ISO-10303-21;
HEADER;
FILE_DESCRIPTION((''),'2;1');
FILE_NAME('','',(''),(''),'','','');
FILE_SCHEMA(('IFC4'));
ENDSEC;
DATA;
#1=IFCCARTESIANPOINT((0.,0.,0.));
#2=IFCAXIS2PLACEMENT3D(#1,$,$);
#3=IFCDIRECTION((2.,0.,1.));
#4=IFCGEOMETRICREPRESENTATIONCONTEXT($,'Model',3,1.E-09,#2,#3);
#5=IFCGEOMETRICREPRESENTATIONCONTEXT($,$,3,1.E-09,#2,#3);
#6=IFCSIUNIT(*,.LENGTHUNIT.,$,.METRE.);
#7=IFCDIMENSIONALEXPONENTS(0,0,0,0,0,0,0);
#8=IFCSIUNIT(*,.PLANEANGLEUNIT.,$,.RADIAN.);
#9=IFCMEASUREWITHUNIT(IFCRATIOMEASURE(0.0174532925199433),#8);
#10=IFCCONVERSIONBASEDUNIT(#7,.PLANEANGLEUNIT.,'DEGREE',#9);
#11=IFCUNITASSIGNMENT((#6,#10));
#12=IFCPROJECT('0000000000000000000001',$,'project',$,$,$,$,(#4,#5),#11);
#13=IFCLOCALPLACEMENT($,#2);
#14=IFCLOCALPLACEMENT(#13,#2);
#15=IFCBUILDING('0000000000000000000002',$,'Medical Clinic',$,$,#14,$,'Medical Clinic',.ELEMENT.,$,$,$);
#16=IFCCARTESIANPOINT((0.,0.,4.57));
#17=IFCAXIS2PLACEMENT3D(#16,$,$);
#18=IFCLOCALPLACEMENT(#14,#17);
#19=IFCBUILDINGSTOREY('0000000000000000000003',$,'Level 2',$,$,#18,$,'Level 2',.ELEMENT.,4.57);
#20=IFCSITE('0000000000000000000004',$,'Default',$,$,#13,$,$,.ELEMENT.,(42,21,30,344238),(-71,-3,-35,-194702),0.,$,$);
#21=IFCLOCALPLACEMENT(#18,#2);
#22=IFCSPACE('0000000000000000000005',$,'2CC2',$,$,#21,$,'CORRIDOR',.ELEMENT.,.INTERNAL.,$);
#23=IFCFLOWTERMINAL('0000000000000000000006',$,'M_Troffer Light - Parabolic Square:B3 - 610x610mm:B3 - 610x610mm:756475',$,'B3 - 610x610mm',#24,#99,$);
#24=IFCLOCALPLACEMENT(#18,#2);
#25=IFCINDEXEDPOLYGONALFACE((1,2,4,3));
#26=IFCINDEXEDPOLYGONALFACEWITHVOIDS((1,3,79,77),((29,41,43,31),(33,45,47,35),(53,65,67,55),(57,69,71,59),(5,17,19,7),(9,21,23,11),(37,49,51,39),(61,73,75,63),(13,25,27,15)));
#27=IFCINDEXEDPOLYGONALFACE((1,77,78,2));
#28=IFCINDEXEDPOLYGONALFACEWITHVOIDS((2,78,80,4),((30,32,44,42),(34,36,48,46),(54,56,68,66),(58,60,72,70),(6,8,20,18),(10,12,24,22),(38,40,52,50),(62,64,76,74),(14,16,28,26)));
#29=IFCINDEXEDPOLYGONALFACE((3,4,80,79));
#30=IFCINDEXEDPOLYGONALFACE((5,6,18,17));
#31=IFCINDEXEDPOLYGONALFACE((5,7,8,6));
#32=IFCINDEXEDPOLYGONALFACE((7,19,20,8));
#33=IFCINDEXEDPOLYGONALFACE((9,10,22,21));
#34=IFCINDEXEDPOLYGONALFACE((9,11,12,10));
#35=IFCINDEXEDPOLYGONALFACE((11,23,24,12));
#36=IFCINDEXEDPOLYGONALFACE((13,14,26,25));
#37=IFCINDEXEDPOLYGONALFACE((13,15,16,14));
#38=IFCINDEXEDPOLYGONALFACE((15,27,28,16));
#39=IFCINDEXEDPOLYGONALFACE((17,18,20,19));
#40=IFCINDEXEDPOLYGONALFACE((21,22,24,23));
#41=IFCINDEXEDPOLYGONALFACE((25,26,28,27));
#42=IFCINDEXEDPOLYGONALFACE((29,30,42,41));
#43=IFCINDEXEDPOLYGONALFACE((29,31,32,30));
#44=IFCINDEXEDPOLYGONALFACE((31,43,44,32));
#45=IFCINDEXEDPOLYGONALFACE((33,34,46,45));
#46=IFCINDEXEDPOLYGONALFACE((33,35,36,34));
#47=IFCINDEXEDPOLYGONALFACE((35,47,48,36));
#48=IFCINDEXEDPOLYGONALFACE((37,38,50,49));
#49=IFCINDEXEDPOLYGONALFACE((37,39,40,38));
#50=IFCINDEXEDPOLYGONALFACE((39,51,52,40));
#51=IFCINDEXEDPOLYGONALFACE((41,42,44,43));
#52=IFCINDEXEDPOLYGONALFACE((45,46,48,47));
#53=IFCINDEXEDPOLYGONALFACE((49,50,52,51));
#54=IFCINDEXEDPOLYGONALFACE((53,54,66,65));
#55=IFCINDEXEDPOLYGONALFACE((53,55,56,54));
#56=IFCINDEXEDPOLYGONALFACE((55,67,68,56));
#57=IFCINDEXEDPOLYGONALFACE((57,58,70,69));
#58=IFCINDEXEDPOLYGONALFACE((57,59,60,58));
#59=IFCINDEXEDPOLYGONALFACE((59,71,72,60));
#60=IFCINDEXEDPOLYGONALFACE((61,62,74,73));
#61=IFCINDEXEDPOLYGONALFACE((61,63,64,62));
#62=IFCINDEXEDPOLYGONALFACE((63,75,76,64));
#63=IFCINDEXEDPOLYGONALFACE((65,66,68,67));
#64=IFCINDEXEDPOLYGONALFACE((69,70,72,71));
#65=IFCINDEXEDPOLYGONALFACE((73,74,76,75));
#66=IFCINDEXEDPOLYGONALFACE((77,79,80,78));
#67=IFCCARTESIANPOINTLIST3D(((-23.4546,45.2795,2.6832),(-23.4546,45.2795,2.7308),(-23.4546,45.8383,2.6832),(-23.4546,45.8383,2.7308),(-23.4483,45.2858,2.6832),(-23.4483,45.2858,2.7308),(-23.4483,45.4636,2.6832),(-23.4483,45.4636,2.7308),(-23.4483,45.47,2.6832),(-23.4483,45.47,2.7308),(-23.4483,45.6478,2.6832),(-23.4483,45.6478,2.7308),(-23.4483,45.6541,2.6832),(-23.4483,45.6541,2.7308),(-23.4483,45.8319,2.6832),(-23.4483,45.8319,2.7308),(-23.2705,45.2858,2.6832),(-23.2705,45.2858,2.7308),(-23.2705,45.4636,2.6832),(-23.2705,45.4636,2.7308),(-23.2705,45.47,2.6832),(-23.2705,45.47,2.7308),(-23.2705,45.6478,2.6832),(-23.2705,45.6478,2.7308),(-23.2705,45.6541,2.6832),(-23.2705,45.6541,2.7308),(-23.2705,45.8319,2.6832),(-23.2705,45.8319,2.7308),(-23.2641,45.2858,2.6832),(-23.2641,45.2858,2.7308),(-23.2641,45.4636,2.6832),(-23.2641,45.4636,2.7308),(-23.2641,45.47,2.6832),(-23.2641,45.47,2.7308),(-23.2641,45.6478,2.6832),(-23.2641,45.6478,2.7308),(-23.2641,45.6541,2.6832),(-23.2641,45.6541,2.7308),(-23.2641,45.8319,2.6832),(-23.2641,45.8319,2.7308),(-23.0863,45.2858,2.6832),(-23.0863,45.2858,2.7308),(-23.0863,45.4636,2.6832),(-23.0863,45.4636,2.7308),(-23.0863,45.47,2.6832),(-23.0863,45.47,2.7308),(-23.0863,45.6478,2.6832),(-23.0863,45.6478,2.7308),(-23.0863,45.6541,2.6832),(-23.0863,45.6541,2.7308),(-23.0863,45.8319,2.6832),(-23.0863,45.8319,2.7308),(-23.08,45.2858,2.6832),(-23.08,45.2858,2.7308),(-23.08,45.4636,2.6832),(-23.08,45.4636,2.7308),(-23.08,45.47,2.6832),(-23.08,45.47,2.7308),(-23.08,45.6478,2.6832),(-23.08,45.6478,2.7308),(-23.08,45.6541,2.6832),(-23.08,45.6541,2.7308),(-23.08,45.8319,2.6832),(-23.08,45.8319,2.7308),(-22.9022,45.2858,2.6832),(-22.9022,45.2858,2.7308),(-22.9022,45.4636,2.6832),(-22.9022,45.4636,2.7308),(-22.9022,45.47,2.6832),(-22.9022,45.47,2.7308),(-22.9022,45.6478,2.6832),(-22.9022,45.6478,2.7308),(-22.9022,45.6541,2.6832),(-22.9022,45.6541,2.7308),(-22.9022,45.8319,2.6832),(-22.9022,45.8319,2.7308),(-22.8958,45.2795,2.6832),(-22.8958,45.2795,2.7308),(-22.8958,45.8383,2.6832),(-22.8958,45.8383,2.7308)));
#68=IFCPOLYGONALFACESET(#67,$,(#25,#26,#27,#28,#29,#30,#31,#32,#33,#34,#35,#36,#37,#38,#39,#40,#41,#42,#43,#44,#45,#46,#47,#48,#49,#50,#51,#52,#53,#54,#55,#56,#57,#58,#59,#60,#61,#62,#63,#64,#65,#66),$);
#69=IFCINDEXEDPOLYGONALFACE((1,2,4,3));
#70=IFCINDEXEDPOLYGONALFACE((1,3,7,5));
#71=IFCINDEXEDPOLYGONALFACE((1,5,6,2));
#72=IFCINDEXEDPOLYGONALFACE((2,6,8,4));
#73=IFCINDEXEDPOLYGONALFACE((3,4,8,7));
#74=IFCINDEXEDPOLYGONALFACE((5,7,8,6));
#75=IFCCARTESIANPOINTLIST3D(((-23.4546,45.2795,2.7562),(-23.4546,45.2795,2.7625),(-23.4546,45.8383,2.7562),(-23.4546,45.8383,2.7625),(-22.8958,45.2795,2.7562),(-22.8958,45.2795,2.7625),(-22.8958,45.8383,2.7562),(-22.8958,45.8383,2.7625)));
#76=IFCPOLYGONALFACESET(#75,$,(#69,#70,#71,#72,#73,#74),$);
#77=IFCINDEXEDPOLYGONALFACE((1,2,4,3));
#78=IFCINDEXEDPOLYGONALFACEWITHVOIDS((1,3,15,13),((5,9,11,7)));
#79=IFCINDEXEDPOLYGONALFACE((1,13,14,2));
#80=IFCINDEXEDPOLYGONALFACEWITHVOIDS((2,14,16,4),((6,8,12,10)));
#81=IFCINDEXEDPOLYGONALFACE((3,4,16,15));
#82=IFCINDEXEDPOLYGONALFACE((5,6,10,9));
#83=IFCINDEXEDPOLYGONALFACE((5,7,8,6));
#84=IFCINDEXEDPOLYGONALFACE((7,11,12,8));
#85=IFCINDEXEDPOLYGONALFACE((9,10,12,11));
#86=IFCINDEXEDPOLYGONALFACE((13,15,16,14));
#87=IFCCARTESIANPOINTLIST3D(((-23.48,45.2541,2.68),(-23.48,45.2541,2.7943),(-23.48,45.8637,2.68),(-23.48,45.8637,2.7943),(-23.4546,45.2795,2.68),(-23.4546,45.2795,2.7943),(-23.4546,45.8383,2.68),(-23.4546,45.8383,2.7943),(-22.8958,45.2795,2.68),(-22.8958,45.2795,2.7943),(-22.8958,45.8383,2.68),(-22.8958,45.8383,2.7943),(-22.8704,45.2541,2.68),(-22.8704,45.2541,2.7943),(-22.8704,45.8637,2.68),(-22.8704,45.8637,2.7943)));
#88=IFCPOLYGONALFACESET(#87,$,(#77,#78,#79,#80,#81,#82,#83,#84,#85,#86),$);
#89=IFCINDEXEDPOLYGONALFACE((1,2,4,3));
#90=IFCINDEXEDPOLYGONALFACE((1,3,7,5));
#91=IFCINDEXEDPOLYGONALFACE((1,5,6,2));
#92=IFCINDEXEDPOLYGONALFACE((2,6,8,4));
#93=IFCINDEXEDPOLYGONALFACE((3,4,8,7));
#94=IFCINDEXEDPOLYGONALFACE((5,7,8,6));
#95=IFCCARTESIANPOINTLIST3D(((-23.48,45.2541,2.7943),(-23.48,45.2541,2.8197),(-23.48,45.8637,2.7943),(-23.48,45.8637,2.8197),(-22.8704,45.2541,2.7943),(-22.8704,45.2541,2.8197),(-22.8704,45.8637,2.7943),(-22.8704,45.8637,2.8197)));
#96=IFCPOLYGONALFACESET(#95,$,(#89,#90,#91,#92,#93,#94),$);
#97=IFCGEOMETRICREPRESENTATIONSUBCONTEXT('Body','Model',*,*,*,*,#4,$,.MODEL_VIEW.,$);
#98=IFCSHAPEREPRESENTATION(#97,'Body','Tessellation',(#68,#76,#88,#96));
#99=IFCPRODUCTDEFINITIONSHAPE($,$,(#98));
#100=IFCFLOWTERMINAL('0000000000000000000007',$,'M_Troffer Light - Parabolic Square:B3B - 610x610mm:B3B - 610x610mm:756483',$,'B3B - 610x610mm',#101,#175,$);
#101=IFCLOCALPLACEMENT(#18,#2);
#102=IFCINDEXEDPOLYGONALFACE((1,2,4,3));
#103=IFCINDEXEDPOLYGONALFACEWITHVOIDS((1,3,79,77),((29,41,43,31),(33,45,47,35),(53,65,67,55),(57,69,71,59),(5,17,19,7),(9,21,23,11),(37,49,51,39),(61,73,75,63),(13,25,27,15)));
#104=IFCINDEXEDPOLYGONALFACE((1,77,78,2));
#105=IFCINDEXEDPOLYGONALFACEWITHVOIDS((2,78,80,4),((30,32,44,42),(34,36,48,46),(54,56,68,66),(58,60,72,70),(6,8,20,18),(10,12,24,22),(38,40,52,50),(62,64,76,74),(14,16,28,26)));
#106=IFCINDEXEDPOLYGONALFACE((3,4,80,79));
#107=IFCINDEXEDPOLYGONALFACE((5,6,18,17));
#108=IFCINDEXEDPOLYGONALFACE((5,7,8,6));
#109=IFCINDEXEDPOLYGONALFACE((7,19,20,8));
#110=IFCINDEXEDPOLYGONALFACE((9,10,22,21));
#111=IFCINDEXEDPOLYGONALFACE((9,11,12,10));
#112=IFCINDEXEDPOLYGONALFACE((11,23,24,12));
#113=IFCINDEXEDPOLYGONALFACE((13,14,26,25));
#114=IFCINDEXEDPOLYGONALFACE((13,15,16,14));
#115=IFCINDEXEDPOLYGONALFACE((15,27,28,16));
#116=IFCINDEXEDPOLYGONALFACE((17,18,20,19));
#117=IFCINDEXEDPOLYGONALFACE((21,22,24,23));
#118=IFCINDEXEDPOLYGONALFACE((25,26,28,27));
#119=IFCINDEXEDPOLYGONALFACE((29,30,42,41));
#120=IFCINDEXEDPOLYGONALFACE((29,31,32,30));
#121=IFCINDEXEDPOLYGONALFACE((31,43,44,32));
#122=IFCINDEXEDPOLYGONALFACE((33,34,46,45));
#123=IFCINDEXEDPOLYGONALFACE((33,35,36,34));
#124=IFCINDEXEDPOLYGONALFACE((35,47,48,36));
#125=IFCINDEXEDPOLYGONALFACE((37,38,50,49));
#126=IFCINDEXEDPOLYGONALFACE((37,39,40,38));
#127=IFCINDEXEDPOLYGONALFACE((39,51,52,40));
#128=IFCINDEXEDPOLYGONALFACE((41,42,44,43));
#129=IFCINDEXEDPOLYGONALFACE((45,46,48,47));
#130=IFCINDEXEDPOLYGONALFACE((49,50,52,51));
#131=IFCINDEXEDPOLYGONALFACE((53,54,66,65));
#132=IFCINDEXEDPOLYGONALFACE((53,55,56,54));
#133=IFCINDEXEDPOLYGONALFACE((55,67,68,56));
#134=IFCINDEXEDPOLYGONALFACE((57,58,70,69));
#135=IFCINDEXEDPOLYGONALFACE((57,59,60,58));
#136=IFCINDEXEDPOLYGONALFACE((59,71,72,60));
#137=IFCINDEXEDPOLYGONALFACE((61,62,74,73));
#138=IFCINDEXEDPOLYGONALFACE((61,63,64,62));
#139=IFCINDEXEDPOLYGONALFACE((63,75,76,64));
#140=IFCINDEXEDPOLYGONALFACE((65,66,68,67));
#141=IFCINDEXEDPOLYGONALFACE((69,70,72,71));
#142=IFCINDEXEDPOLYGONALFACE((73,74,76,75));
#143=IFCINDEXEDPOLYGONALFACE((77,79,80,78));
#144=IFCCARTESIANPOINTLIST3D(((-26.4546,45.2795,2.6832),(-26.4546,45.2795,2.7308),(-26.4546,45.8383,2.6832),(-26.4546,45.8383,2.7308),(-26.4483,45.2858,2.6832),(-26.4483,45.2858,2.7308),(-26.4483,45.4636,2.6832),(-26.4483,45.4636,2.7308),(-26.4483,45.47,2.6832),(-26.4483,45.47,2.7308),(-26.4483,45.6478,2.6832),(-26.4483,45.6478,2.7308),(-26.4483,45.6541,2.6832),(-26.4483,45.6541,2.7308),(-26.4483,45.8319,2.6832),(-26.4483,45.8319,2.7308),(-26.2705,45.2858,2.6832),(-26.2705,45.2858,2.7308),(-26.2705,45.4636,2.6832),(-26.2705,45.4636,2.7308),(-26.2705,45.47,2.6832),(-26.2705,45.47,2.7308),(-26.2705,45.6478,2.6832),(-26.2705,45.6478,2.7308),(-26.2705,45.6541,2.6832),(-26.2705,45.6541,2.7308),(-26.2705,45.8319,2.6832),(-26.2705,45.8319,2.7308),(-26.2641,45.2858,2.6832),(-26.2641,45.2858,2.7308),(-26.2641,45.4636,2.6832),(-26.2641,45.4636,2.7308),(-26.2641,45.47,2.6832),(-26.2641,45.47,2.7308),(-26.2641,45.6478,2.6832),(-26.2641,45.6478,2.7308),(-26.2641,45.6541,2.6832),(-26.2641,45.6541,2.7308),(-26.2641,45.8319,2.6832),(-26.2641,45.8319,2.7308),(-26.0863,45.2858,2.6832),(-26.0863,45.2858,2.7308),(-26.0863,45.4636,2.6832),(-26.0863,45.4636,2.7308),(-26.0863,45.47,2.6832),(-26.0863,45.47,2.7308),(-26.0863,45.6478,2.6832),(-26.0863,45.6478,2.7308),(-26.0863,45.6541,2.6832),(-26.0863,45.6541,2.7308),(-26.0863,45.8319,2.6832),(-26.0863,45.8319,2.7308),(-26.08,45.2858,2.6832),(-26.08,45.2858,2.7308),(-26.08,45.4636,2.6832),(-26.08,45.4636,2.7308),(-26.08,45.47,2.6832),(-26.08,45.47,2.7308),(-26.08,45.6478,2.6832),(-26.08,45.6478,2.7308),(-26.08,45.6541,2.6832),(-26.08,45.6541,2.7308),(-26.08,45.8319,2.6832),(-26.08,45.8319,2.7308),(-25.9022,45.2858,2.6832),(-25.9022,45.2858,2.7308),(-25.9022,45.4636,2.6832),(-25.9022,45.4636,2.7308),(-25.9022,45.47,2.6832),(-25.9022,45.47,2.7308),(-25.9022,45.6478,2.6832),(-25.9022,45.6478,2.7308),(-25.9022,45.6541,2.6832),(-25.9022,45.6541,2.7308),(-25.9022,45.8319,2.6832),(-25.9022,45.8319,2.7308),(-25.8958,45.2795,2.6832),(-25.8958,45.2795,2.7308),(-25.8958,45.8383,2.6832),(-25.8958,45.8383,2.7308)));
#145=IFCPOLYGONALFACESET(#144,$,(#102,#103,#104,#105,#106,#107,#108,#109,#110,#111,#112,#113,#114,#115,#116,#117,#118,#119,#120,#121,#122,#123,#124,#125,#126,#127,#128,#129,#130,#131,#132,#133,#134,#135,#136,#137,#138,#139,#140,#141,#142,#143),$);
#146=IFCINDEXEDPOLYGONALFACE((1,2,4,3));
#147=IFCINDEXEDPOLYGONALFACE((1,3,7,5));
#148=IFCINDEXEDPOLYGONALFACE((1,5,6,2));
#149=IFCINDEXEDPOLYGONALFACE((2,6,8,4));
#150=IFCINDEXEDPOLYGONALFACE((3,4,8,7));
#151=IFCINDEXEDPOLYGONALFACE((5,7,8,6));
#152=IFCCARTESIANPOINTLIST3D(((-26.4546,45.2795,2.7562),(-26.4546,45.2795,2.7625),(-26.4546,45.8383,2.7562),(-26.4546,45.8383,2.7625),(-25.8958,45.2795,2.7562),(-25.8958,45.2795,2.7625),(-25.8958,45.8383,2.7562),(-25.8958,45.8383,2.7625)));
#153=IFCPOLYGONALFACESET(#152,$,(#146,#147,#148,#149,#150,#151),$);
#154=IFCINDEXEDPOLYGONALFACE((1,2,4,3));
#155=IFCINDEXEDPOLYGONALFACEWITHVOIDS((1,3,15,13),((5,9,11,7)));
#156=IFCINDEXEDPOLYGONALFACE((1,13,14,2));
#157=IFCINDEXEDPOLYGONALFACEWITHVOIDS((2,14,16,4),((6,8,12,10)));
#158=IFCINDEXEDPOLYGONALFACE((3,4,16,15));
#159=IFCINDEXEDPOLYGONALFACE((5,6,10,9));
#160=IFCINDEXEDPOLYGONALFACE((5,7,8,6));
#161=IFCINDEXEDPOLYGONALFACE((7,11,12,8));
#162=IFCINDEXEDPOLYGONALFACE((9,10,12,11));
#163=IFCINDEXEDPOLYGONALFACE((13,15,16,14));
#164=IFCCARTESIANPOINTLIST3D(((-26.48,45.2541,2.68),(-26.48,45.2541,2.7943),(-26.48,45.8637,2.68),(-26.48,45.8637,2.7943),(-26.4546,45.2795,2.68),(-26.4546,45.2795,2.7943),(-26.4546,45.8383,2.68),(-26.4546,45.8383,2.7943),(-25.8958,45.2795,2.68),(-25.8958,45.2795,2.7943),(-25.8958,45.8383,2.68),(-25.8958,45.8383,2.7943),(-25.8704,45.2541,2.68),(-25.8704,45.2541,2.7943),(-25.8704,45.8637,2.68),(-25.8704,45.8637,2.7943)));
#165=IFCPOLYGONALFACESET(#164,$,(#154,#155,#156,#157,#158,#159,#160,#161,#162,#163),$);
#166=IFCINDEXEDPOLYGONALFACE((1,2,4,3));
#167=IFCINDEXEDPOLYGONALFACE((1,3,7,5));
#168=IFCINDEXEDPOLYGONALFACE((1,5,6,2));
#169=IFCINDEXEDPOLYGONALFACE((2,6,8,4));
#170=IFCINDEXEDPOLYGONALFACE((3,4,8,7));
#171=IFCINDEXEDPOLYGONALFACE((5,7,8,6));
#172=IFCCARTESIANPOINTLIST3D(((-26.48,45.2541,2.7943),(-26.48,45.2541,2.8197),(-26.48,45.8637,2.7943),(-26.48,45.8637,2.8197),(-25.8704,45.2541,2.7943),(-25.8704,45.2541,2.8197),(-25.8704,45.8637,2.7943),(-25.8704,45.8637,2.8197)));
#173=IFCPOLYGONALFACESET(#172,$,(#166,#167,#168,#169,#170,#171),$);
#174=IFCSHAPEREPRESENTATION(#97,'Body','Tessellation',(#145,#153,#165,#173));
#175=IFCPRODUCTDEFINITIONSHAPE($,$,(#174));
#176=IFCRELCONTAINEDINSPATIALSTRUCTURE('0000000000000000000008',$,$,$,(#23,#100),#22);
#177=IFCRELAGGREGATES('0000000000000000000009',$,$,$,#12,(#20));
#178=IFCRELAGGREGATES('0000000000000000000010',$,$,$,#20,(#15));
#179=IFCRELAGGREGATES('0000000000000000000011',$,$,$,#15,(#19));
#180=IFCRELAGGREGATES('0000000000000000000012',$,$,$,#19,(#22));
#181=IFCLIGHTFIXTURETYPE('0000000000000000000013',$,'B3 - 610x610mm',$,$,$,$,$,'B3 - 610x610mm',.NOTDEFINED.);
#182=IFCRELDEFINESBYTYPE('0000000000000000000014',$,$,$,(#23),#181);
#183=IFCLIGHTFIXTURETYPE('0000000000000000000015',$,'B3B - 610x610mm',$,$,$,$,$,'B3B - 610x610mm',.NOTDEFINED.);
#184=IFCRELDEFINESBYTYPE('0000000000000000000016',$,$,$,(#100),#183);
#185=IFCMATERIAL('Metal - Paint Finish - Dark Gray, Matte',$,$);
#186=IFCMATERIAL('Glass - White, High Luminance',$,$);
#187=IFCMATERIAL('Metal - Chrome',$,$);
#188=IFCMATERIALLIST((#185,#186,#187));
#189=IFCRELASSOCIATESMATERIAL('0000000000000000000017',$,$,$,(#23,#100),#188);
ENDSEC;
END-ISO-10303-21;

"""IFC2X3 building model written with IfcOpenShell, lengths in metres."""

from ifc_helpers import new_model, entity, si_unit, converted_unit, direction, frame, origin, origin_2d_with_axis, place, context, subcontext, project, spatial, polyline, rectangle, outline, extrude, source, transform, mapped, material, material_list, type_object, type_shapes, element, save


model = new_model("IFC2X3")

# Units and contexts
model_context = context("Model", 3, precision=1e-09, world=origin(), true_north=direction((2.0, 0.0, 1.0)))
context_of_model = context(None, 3, precision=1e-09, world=origin(), true_north=direction((2.0, 0.0, 1.0)))
body_context = subcontext(model_context, "Body", "Model", "MODEL_VIEW")
ifc_project = project(units=[si_unit("LENGTHUNIT", "METRE"), converted_unit("PLANEANGLEUNIT", "DEGREE", entity("IfcRatioMeasure", 0.0174532925199433), si_unit("PLANEANGLEUNIT", "RADIAN"), dimensions=[0, 0, 0, 0, 0, 0, 0])], contexts=[model_context, context_of_model])

# Site, building, storey
site_placement = place(None, origin())
site = spatial("IfcSite", under=ifc_project, at=site_placement, Name="Default", CompositionType="ELEMENT", RefLatitude=(42, 21, 30, 344238), RefLongitude=(-71, -3, -35, -194702), RefElevation=0.0)
building_placement = place(site_placement, origin())
building = spatial("IfcBuilding", under=site, at=building_placement, Name="Medical Clinic", LongName="Medical Clinic", CompositionType="ELEMENT")
storey_placement = place(building_placement, frame((0.0, 0.0, 4.57)))
storey = spatial("IfcBuildingStorey", under=building, at=storey_placement, Name="Level 2", LongName="Level 2", CompositionType="ELEMENT", Elevation=4.57)

# Shared definitions
space_1_placement = place(storey_placement, origin())
space_1 = spatial("IfcSpace", under=storey, at=space_1_placement, Name="2CC2", LongName="CORRIDOR", CompositionType="ELEMENT", InteriorOrExteriorSpace="INTERNAL")

# Flow terminals
ifc_material_1 = material(Name="Metal - Paint Finish - Dark Gray, Matte")
ifc_material_2 = material(Name="Glass - White, High Luminance")
ifc_material_3 = material(Name="Metal - Chrome")
ifc_material_list_1 = material_list([ifc_material_1, ifc_material_2, ifc_material_3])
light_fixture_type_1 = type_object("IfcLightFixtureType", Name="B3 - 610x610mm", ElementType="B3 - 610x610mm", PredefinedType="NOTDEFINED")
shared_shape_1 = source(origin(), body_context, "Body", "SweptSolid", [
    extrude(outline(polyline([(-0.2794, -0.2794), (0.2794, -0.2794), (0.2794, 0.2794), (-0.2794, 0.2794), (-0.2794, -0.2794)]), holes=[polyline([(-0.0952, 0.0953), (-0.273, 0.0953), (-0.273, 0.2731), (-0.0952, 0.2731), (-0.0952, 0.0953)]), polyline([(0.2731, 0.0953), (0.0953, 0.0953), (0.0953, 0.2731), (0.2731, 0.2731), (0.2731, 0.0953)]), polyline([(-0.0889, 0.2731), (0.0889, 0.2731), (0.0889, 0.0953), (-0.0889, 0.0953), (-0.0889, 0.2731)]), polyline([(0.2731, -0.273), (0.0953, -0.273), (0.0953, -0.0952), (0.2731, -0.0952), (0.2731, -0.273)]), polyline([(0.0889, -0.273), (-0.0889, -0.273), (-0.0889, -0.0952), (0.0889, -0.0952), (0.0889, -0.273)]), polyline([(-0.0952, -0.273), (-0.273, -0.273), (-0.273, -0.0952), (-0.0952, -0.0952), (-0.0952, -0.273)]), polyline([(-0.0952, -0.0889), (-0.273, -0.0889), (-0.273, 0.0889), (-0.0952, 0.0889), (-0.0952, -0.0889)]), polyline([(0.0889, -0.0889), (-0.0889, -0.0889), (-0.0889, 0.0889), (0.0889, 0.0889), (0.0889, -0.0889)]), polyline([(0.2731, -0.0889), (0.0953, -0.0889), (0.0953, 0.0889), (0.2731, 0.0889), (0.2731, -0.0889)])]), frame((0.0, -0.3048, -0.0508), z_axis=(0.0, 0.0, 1.0), x_axis=(-1.0, 0.0, 0.0)), (0.0, 0.0, 1.0), 0.0476),
    extrude(rectangle(XDim=0.5588, YDim=0.5588, at=origin_2d_with_axis()), frame((0.0, -0.3048, -0.0825), z_axis=(0.0, 0.0, 1.0), x_axis=(-1.0, 0.0, 0.0)), (0.0, 0.0, 1.0), 0.0064),
    extrude(outline(polyline([(-0.3048, -0.3048), (0.3048, -0.3048), (0.3048, 0.3048), (-0.3048, 0.3048), (-0.3048, -0.3048)]), holes=[polyline([(0.2794, 0.2794), (0.2794, -0.2794), (-0.2794, -0.2794), (-0.2794, 0.2794), (0.2794, 0.2794)])]), frame((0.0, -0.3048, -0.1143)), (0.0, 0.0, 1.0), 0.1143),
    extrude(rectangle(XDim=0.6096, YDim=0.6096, at=origin_2d_with_axis()), frame((0.0, -0.3048, -0.1397), z_axis=(0.0, 0.0, 1.0), x_axis=(-1.0, 0.0, 0.0)), (0.0, 0.0, 1.0), 0.0254),
])
type_shapes(light_fixture_type_1, [shared_shape_1])
flow_terminal_1_placement = place(space_1_placement, frame((-23.1752, 45.2541, 2.68), z_axis=(0.0, 0.0, -1.0), x_axis=(1.0, 0.0, 0.0)))
element("IfcFlowTerminal", 1, at=flow_terminal_1_placement, inside=space_1, type_object=light_fixture_type_1, material=ifc_material_list_1, Name="M_Troffer Light - Parabolic Square:B3 - 610x610mm:B3 - 610x610mm:756475", ObjectType="B3 - 610x610mm", context=body_context, shape_type="MappedRepresentation", body=[
    mapped(shared_shape_1, transform((0.0, 0.0, 0.0), scale=1.0)),
])
light_fixture_type_2 = type_object("IfcLightFixtureType", Name="B3B - 610x610mm", ElementType="B3B - 610x610mm", PredefinedType="NOTDEFINED")
shared_shape_2 = source(origin(), body_context, "Body", "SweptSolid", [
    extrude(outline(polyline([(-0.2794, -0.2794), (0.2794, -0.2794), (0.2794, 0.2794), (-0.2794, 0.2794), (-0.2794, -0.2794)]), holes=[polyline([(-0.0952, 0.0953), (-0.273, 0.0953), (-0.273, 0.2731), (-0.0952, 0.2731), (-0.0952, 0.0953)]), polyline([(0.2731, 0.0953), (0.0953, 0.0953), (0.0953, 0.2731), (0.2731, 0.2731), (0.2731, 0.0953)]), polyline([(-0.0889, 0.2731), (0.0889, 0.2731), (0.0889, 0.0953), (-0.0889, 0.0953), (-0.0889, 0.2731)]), polyline([(0.2731, -0.273), (0.0953, -0.273), (0.0953, -0.0952), (0.2731, -0.0952), (0.2731, -0.273)]), polyline([(0.0889, -0.273), (-0.0889, -0.273), (-0.0889, -0.0952), (0.0889, -0.0952), (0.0889, -0.273)]), polyline([(-0.0952, -0.273), (-0.273, -0.273), (-0.273, -0.0952), (-0.0952, -0.0952), (-0.0952, -0.273)]), polyline([(-0.0952, -0.0889), (-0.273, -0.0889), (-0.273, 0.0889), (-0.0952, 0.0889), (-0.0952, -0.0889)]), polyline([(0.0889, -0.0889), (-0.0889, -0.0889), (-0.0889, 0.0889), (0.0889, 0.0889), (0.0889, -0.0889)]), polyline([(0.2731, -0.0889), (0.0953, -0.0889), (0.0953, 0.0889), (0.2731, 0.0889), (0.2731, -0.0889)])]), frame((0.0, -0.3048, -0.0508), z_axis=(0.0, 0.0, 1.0), x_axis=(-1.0, 0.0, 0.0)), (0.0, 0.0, 1.0), 0.0476),
    extrude(rectangle(XDim=0.5588, YDim=0.5588, at=origin_2d_with_axis()), frame((0.0, -0.3048, -0.0825), z_axis=(0.0, 0.0, 1.0), x_axis=(-1.0, 0.0, 0.0)), (0.0, 0.0, 1.0), 0.0064),
    extrude(outline(polyline([(-0.3048, -0.3048), (0.3048, -0.3048), (0.3048, 0.3048), (-0.3048, 0.3048), (-0.3048, -0.3048)]), holes=[polyline([(0.2794, 0.2794), (0.2794, -0.2794), (-0.2794, -0.2794), (-0.2794, 0.2794), (0.2794, 0.2794)])]), frame((0.0, -0.3048, -0.1143)), (0.0, 0.0, 1.0), 0.1143),
    extrude(rectangle(XDim=0.6096, YDim=0.6096, at=origin_2d_with_axis()), frame((0.0, -0.3048, -0.1397), z_axis=(0.0, 0.0, 1.0), x_axis=(-1.0, 0.0, 0.0)), (0.0, 0.0, 1.0), 0.0254),
])
type_shapes(light_fixture_type_2, [shared_shape_2])
flow_terminal_2_placement = place(space_1_placement, frame((-26.1752, 45.2541, 2.68), z_axis=(0.0, 0.0, -1.0), x_axis=(1.0, 0.0, 0.0)))
element("IfcFlowTerminal", 2, at=flow_terminal_2_placement, inside=space_1, type_object=light_fixture_type_2, material=ifc_material_list_1, Name="M_Troffer Light - Parabolic Square:B3B - 610x610mm:B3B - 610x610mm:756483", ObjectType="B3B - 610x610mm", context=body_context, shape_type="MappedRepresentation", body=[
    mapped(shared_shape_2, transform((0.0, 0.0, 0.0), scale=1.0)),
])

save(model, "model.ifc")
